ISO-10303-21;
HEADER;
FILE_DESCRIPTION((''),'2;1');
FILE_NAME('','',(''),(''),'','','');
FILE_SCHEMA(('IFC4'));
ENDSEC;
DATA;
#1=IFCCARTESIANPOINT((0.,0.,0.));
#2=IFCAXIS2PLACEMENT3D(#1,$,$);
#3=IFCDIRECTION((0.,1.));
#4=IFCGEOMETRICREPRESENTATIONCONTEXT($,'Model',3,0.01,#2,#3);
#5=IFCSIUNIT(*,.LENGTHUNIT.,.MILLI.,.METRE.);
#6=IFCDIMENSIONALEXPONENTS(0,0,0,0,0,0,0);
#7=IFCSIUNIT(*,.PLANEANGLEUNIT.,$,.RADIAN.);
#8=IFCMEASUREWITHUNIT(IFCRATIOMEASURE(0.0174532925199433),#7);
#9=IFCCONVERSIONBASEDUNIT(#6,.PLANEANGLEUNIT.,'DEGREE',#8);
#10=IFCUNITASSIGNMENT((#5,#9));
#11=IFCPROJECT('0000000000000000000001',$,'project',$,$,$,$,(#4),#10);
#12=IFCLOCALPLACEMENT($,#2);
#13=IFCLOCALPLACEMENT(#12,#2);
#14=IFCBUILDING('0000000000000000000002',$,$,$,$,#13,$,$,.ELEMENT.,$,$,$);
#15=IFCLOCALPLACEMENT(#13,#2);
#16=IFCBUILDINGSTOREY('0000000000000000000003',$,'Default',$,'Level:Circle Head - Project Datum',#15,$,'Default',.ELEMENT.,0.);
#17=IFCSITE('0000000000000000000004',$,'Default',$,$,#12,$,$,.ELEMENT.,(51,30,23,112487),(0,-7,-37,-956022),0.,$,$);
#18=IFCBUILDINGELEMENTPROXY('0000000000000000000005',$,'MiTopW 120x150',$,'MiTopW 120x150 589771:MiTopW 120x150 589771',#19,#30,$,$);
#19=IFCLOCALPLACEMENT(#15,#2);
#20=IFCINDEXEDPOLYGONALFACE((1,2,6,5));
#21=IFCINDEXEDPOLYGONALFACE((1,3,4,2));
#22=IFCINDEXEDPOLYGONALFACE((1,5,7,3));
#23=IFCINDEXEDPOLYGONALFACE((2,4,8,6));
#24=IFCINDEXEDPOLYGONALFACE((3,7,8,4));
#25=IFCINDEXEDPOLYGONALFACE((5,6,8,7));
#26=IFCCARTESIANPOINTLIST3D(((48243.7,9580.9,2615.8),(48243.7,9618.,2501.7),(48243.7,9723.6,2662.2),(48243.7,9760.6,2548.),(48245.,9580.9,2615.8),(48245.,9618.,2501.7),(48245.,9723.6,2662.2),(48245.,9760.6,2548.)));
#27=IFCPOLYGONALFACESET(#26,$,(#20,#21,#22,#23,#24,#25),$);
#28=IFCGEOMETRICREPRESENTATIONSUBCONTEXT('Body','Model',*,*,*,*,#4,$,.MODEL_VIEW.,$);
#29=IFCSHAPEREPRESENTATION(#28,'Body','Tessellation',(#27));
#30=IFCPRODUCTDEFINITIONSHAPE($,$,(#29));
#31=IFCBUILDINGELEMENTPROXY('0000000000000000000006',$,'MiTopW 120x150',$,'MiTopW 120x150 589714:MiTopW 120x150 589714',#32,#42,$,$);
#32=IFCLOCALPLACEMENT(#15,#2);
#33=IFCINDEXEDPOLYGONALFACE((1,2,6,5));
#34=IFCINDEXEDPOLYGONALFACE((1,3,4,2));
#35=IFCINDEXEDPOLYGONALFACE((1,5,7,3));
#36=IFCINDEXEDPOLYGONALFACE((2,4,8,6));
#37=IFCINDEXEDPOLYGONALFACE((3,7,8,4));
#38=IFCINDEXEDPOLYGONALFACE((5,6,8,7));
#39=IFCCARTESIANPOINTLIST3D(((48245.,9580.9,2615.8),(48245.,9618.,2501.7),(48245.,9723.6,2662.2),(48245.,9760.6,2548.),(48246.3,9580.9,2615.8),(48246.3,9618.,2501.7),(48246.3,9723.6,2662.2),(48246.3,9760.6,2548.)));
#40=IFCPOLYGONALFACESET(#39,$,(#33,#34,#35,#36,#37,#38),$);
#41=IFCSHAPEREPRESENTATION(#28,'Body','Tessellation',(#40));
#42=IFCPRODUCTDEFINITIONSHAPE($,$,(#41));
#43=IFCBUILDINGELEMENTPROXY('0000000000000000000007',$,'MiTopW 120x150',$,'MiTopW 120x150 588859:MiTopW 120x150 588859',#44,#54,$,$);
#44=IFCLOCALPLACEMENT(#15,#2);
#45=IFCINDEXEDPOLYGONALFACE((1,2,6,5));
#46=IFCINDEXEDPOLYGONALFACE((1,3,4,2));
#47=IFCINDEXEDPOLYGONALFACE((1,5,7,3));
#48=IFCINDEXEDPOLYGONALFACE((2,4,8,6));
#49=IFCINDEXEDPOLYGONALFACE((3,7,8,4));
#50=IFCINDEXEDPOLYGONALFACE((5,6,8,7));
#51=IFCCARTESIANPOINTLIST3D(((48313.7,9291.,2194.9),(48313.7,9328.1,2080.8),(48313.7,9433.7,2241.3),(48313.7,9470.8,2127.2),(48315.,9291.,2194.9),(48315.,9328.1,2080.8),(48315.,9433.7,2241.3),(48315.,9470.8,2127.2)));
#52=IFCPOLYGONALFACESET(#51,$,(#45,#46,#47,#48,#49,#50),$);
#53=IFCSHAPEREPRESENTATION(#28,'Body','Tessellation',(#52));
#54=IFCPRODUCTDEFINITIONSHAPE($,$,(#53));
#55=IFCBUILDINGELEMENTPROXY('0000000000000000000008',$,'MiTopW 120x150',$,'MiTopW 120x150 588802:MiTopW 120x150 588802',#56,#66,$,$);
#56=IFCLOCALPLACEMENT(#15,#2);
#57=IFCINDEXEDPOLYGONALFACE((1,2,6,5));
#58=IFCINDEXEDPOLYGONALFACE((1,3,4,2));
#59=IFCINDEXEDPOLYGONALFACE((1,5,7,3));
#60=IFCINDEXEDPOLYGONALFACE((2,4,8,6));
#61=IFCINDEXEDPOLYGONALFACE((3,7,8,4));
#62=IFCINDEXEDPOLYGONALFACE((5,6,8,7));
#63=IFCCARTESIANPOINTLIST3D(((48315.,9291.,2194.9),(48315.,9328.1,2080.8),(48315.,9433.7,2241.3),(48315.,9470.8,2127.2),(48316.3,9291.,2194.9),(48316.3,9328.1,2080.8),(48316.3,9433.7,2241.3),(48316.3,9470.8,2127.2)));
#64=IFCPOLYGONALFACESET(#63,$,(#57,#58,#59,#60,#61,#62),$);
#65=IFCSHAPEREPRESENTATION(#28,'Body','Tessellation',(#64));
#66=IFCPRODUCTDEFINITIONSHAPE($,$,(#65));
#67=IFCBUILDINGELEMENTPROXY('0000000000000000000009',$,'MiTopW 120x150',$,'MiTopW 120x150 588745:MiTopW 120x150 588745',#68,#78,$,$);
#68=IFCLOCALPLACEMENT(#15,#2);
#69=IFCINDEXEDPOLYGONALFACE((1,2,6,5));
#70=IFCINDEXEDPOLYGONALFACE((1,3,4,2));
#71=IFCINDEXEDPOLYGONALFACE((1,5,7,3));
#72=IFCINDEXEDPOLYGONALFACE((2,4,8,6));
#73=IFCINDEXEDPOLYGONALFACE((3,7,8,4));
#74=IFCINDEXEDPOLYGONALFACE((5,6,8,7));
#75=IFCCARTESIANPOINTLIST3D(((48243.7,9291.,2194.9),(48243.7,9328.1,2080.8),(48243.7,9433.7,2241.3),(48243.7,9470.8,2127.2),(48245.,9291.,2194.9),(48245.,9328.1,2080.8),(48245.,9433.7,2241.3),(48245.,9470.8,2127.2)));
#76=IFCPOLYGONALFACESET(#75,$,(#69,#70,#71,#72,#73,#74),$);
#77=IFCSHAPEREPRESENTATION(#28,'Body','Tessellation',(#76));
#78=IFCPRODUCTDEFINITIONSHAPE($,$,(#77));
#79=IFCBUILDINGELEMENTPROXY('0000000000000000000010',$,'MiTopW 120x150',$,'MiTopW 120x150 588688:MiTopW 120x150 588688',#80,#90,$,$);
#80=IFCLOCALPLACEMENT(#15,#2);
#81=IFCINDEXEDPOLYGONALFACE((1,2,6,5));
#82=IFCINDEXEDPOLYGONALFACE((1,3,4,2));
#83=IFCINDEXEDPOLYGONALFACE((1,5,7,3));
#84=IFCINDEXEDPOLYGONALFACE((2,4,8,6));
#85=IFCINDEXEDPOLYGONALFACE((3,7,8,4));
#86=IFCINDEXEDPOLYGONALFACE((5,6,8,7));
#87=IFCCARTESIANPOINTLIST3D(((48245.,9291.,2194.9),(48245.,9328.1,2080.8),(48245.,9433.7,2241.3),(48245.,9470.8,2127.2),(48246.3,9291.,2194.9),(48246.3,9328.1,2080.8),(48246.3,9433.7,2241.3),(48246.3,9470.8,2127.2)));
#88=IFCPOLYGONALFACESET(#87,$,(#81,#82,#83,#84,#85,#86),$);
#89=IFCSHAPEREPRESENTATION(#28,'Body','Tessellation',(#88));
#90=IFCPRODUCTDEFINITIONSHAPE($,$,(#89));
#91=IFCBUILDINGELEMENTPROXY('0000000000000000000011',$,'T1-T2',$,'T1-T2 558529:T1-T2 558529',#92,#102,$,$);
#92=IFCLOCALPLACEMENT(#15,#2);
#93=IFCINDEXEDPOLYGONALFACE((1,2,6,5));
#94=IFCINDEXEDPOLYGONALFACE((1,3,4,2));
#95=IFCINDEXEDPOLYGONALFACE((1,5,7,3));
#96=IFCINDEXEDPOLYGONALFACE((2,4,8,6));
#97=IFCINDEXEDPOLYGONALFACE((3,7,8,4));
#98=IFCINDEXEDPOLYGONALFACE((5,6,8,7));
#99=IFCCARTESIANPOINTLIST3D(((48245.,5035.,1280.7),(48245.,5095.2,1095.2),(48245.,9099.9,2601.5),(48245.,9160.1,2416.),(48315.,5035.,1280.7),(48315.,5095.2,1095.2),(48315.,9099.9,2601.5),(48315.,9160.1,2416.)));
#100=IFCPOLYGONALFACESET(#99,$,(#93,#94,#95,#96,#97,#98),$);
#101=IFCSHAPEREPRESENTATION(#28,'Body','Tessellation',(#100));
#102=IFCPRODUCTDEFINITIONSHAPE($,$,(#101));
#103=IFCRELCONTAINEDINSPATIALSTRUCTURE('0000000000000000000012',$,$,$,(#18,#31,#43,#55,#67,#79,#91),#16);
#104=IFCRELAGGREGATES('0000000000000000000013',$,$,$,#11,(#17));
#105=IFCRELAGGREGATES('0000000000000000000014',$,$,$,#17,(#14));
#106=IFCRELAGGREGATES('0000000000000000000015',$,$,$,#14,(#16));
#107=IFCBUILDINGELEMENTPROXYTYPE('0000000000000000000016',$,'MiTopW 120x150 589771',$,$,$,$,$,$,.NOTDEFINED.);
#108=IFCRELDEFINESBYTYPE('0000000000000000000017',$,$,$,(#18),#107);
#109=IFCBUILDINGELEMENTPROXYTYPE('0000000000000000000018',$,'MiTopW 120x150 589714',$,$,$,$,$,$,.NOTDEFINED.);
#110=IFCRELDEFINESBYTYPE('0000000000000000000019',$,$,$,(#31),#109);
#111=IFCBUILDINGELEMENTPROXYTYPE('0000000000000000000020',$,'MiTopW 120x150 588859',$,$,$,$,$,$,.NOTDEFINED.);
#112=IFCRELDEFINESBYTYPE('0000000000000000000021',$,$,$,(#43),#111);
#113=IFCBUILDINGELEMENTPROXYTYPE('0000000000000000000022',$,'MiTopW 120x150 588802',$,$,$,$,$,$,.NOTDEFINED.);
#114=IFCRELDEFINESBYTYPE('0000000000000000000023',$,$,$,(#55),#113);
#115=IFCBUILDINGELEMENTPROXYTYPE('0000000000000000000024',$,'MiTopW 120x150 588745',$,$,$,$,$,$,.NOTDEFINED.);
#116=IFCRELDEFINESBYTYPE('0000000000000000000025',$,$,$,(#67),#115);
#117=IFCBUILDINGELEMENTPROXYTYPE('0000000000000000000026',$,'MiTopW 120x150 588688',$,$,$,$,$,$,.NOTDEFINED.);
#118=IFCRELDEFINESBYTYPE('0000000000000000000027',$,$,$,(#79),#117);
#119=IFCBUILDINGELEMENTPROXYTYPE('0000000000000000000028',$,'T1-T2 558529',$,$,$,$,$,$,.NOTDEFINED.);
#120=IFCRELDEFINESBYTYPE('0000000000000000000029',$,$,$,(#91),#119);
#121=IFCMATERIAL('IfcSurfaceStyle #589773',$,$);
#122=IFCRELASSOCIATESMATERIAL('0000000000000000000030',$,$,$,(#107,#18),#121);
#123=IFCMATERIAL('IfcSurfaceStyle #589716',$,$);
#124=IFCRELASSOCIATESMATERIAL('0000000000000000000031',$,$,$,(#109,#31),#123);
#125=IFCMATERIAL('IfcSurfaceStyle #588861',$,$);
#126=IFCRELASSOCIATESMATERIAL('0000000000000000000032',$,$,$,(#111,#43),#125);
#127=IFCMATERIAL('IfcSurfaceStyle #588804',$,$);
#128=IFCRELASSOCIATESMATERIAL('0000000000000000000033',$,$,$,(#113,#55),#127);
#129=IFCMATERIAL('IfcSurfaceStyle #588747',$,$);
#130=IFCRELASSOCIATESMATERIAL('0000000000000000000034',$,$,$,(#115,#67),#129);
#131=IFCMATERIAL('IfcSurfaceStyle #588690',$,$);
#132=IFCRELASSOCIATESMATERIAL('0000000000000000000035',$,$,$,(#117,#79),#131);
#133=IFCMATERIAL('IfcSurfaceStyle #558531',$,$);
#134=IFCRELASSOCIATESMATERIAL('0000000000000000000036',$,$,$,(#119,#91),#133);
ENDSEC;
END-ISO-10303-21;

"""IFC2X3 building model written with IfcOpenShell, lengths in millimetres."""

from ifc_helpers import new_model, entity, si_unit, converted_unit, direction, frame, origin, place, context, subcontext, project, spatial, polyline, outline, extrude, source, transform, mapped, material, type_object, type_shapes, element, save


model = new_model("IFC2X3")

# Units and contexts
model_context = context("Model", 3, precision=0.01, world=origin(), true_north=direction((0.0, 1.0)))
body_context = subcontext(model_context, "Body", "Model", "MODEL_VIEW")
ifc_project = project(units=[si_unit("LENGTHUNIT", "METRE", prefix="MILLI"), converted_unit("PLANEANGLEUNIT", "DEGREE", entity("IfcRatioMeasure", 0.0174532925199433), si_unit("PLANEANGLEUNIT", "RADIAN"), dimensions=[0, 0, 0, 0, 0, 0, 0])], contexts=[model_context])

# Site, building, storey
site_placement = place(None, origin())
site = spatial("IfcSite", under=ifc_project, at=site_placement, Name="Default", CompositionType="ELEMENT", RefLatitude=(51, 30, 23, 112487), RefLongitude=(0, -7, -37, -956022), RefElevation=0.0)
building_placement = place(site_placement, origin())
building = spatial("IfcBuilding", under=site, at=building_placement, CompositionType="ELEMENT")
storey_placement = place(building_placement, origin())
storey = spatial("IfcBuildingStorey", under=building, at=storey_placement, Name="Default", ObjectType="Level:Circle Head - Project Datum", LongName="Default", CompositionType="ELEMENT", Elevation=0.0)

# Building element proxies
ifc_material_1 = material(Name="IfcSurfaceStyle #589773")
building_element_proxy_type_1 = type_object("IfcBuildingElementProxyType", Name="MiTopW 120x150 589771", PredefinedType="NOTDEFINED", material=ifc_material_1)
shared_shape_1 = source(origin(), body_context, "Body", "SweptSolid", [
    extrude(outline(polyline([(-75.0, -60.0), (75.0, -60.0), (75.0, 60.0), (-75.0, 60.0), (-75.0, -60.0)])), frame((75.0, 60.0, 0.0), z_axis=(0.0, 0.0, 1.0), x_axis=(-1.0, 0.0, 0.0)), (0.0, 0.0, 1.0), 1.3),
])
type_shapes(building_element_proxy_type_1, [shared_shape_1])
proxy_1_placement = place(building_placement, frame((48245.0, 9580.9, 2615.8), z_axis=(-1.0, 0.0, 0.0), x_axis=(0.0, 0.951057, 0.309017)))
element("IfcBuildingElementProxy", 1, at=proxy_1_placement, inside=storey, type_object=building_element_proxy_type_1, material=ifc_material_1, Name="MiTopW 120x150", ObjectType="MiTopW 120x150 589771:MiTopW 120x150 589771", context=body_context, shape_type="MappedRepresentation", body=[
    mapped(shared_shape_1, transform((0.0, 0.0, 0.0), scale=1.0)),
])
ifc_material_2 = material(Name="IfcSurfaceStyle #589716")
building_element_proxy_type_2 = type_object("IfcBuildingElementProxyType", Name="MiTopW 120x150 589714", PredefinedType="NOTDEFINED", material=ifc_material_2)
shared_shape_2 = source(origin(), body_context, "Body", "SweptSolid", [
    extrude(outline(polyline([(-75.0, -60.0), (75.0, -60.0), (75.0, 60.0), (-75.0, 60.0), (-75.0, -60.0)])), frame((75.0, 60.0, 0.0), z_axis=(0.0, 0.0, 1.0), x_axis=(-1.0, 0.0, 0.0)), (0.0, 0.0, 1.0), 1.3),
])
type_shapes(building_element_proxy_type_2, [shared_shape_2])
proxy_2_placement = place(building_placement, frame((48246.3, 9580.9, 2615.8), z_axis=(-1.0, 0.0, 0.0), x_axis=(0.0, 0.951057, 0.309017)))
element("IfcBuildingElementProxy", 2, at=proxy_2_placement, inside=storey, type_object=building_element_proxy_type_2, material=ifc_material_2, Name="MiTopW 120x150", ObjectType="MiTopW 120x150 589714:MiTopW 120x150 589714", context=body_context, shape_type="MappedRepresentation", body=[
    mapped(shared_shape_2, transform((0.0, 0.0, 0.0), scale=1.0)),
])
ifc_material_3 = material(Name="IfcSurfaceStyle #588861")
building_element_proxy_type_3 = type_object("IfcBuildingElementProxyType", Name="MiTopW 120x150 588859", PredefinedType="NOTDEFINED", material=ifc_material_3)
shared_shape_3 = source(origin(), body_context, "Body", "SweptSolid", [
    extrude(outline(polyline([(-75.0, -60.0), (75.0, -60.0), (75.0, 60.0), (-75.0, 60.0), (-75.0, -60.0)])), frame((75.0, 60.0, 0.0), z_axis=(0.0, 0.0, 1.0), x_axis=(-1.0, 0.0, 0.0)), (0.0, 0.0, 1.0), 1.3),
])
type_shapes(building_element_proxy_type_3, [shared_shape_3])
proxy_3_placement = place(building_placement, frame((48315.0, 9291.0, 2194.9), z_axis=(-1.0, 0.0, 0.0), x_axis=(0.0, 0.951057, 0.309017)))
element("IfcBuildingElementProxy", 3, at=proxy_3_placement, inside=storey, type_object=building_element_proxy_type_3, material=ifc_material_3, Name="MiTopW 120x150", ObjectType="MiTopW 120x150 588859:MiTopW 120x150 588859", context=body_context, shape_type="MappedRepresentation", body=[
    mapped(shared_shape_3, transform((0.0, 0.0, 0.0), scale=1.0)),
])
ifc_material_4 = material(Name="IfcSurfaceStyle #588804")
building_element_proxy_type_4 = type_object("IfcBuildingElementProxyType", Name="MiTopW 120x150 588802", PredefinedType="NOTDEFINED", material=ifc_material_4)
shared_shape_4 = source(origin(), body_context, "Body", "SweptSolid", [
    extrude(outline(polyline([(-75.0, -60.0), (75.0, -60.0), (75.0, 60.0), (-75.0, 60.0), (-75.0, -60.0)])), frame((75.0, 60.0, 0.0), z_axis=(0.0, 0.0, 1.0), x_axis=(-1.0, 0.0, 0.0)), (0.0, 0.0, 1.0), 1.3),
])
type_shapes(building_element_proxy_type_4, [shared_shape_4])
proxy_4_placement = place(building_placement, frame((48316.3, 9291.0, 2194.9), z_axis=(-1.0, 0.0, 0.0), x_axis=(0.0, 0.951057, 0.309017)))
element("IfcBuildingElementProxy", 4, at=proxy_4_placement, inside=storey, type_object=building_element_proxy_type_4, material=ifc_material_4, Name="MiTopW 120x150", ObjectType="MiTopW 120x150 588802:MiTopW 120x150 588802", context=body_context, shape_type="MappedRepresentation", body=[
    mapped(shared_shape_4, transform((0.0, 0.0, 0.0), scale=1.0)),
])
ifc_material_5 = material(Name="IfcSurfaceStyle #588747")
building_element_proxy_type_5 = type_object("IfcBuildingElementProxyType", Name="MiTopW 120x150 588745", PredefinedType="NOTDEFINED", material=ifc_material_5)
shared_shape_5 = source(origin(), body_context, "Body", "SweptSolid", [
    extrude(outline(polyline([(-75.0, -60.0), (75.0, -60.0), (75.0, 60.0), (-75.0, 60.0), (-75.0, -60.0)])), frame((75.0, 60.0, 0.0), z_axis=(0.0, 0.0, 1.0), x_axis=(-1.0, 0.0, 0.0)), (0.0, 0.0, 1.0), 1.3),
])
type_shapes(building_element_proxy_type_5, [shared_shape_5])
proxy_5_placement = place(building_placement, frame((48245.0, 9291.0, 2194.9), z_axis=(-1.0, 0.0, 0.0), x_axis=(0.0, 0.951057, 0.309017)))
element("IfcBuildingElementProxy", 5, at=proxy_5_placement, inside=storey, type_object=building_element_proxy_type_5, material=ifc_material_5, Name="MiTopW 120x150", ObjectType="MiTopW 120x150 588745:MiTopW 120x150 588745", context=body_context, shape_type="MappedRepresentation", body=[
    mapped(shared_shape_5, transform((0.0, 0.0, 0.0), scale=1.0)),
])
ifc_material_6 = material(Name="IfcSurfaceStyle #588690")
building_element_proxy_type_6 = type_object("IfcBuildingElementProxyType", Name="MiTopW 120x150 588688", PredefinedType="NOTDEFINED", material=ifc_material_6)
shared_shape_6 = source(origin(), body_context, "Body", "SweptSolid", [
    extrude(outline(polyline([(-75.0, -60.0), (75.0, -60.0), (75.0, 60.0), (-75.0, 60.0), (-75.0, -60.0)])), frame((75.0, 60.0, 0.0), z_axis=(0.0, 0.0, 1.0), x_axis=(-1.0, 0.0, 0.0)), (0.0, 0.0, 1.0), 1.3),
])
type_shapes(building_element_proxy_type_6, [shared_shape_6])
proxy_6_placement = place(building_placement, frame((48246.3, 9291.0, 2194.9), z_axis=(-1.0, 0.0, 0.0), x_axis=(0.0, 0.951057, 0.309017)))
element("IfcBuildingElementProxy", 6, at=proxy_6_placement, inside=storey, type_object=building_element_proxy_type_6, material=ifc_material_6, Name="MiTopW 120x150", ObjectType="MiTopW 120x150 588688:MiTopW 120x150 588688", context=body_context, shape_type="MappedRepresentation", body=[
    mapped(shared_shape_6, transform((0.0, 0.0, 0.0), scale=1.0)),
])
ifc_material_7 = material(Name="IfcSurfaceStyle #558531")
building_element_proxy_type_7 = type_object("IfcBuildingElementProxyType", Name="T1-T2 558529", PredefinedType="NOTDEFINED", material=ifc_material_7)
shared_shape_7 = source(origin(), body_context, "Body", "SweptSolid", [
    extrude(outline(polyline([(-2137.0, -97.5), (2137.0, -97.5), (2137.0, 97.5), (-2137.0, 97.5), (-2137.0, -97.5)])), frame((2137.0, 97.5, 0.0), z_axis=(0.0, 0.0, 1.0), x_axis=(-1.0, 0.0, 0.0)), (0.0, 0.0, 1.0), 70.0),
])
type_shapes(building_element_proxy_type_7, [shared_shape_7])
proxy_7_placement = place(building_placement, frame((48315.0, 9160.1, 2416.0), z_axis=(-1.0, 0.0, 0.0), x_axis=(0.0, -0.951057, -0.309017)))
element("IfcBuildingElementProxy", 7, at=proxy_7_placement, inside=storey, type_object=building_element_proxy_type_7, material=ifc_material_7, Name="T1-T2", ObjectType="T1-T2 558529:T1-T2 558529", context=body_context, shape_type="MappedRepresentation", body=[
    mapped(shared_shape_7, transform((0.0, 0.0, 0.0), scale=1.0)),
])

save(model, "model.ifc")
